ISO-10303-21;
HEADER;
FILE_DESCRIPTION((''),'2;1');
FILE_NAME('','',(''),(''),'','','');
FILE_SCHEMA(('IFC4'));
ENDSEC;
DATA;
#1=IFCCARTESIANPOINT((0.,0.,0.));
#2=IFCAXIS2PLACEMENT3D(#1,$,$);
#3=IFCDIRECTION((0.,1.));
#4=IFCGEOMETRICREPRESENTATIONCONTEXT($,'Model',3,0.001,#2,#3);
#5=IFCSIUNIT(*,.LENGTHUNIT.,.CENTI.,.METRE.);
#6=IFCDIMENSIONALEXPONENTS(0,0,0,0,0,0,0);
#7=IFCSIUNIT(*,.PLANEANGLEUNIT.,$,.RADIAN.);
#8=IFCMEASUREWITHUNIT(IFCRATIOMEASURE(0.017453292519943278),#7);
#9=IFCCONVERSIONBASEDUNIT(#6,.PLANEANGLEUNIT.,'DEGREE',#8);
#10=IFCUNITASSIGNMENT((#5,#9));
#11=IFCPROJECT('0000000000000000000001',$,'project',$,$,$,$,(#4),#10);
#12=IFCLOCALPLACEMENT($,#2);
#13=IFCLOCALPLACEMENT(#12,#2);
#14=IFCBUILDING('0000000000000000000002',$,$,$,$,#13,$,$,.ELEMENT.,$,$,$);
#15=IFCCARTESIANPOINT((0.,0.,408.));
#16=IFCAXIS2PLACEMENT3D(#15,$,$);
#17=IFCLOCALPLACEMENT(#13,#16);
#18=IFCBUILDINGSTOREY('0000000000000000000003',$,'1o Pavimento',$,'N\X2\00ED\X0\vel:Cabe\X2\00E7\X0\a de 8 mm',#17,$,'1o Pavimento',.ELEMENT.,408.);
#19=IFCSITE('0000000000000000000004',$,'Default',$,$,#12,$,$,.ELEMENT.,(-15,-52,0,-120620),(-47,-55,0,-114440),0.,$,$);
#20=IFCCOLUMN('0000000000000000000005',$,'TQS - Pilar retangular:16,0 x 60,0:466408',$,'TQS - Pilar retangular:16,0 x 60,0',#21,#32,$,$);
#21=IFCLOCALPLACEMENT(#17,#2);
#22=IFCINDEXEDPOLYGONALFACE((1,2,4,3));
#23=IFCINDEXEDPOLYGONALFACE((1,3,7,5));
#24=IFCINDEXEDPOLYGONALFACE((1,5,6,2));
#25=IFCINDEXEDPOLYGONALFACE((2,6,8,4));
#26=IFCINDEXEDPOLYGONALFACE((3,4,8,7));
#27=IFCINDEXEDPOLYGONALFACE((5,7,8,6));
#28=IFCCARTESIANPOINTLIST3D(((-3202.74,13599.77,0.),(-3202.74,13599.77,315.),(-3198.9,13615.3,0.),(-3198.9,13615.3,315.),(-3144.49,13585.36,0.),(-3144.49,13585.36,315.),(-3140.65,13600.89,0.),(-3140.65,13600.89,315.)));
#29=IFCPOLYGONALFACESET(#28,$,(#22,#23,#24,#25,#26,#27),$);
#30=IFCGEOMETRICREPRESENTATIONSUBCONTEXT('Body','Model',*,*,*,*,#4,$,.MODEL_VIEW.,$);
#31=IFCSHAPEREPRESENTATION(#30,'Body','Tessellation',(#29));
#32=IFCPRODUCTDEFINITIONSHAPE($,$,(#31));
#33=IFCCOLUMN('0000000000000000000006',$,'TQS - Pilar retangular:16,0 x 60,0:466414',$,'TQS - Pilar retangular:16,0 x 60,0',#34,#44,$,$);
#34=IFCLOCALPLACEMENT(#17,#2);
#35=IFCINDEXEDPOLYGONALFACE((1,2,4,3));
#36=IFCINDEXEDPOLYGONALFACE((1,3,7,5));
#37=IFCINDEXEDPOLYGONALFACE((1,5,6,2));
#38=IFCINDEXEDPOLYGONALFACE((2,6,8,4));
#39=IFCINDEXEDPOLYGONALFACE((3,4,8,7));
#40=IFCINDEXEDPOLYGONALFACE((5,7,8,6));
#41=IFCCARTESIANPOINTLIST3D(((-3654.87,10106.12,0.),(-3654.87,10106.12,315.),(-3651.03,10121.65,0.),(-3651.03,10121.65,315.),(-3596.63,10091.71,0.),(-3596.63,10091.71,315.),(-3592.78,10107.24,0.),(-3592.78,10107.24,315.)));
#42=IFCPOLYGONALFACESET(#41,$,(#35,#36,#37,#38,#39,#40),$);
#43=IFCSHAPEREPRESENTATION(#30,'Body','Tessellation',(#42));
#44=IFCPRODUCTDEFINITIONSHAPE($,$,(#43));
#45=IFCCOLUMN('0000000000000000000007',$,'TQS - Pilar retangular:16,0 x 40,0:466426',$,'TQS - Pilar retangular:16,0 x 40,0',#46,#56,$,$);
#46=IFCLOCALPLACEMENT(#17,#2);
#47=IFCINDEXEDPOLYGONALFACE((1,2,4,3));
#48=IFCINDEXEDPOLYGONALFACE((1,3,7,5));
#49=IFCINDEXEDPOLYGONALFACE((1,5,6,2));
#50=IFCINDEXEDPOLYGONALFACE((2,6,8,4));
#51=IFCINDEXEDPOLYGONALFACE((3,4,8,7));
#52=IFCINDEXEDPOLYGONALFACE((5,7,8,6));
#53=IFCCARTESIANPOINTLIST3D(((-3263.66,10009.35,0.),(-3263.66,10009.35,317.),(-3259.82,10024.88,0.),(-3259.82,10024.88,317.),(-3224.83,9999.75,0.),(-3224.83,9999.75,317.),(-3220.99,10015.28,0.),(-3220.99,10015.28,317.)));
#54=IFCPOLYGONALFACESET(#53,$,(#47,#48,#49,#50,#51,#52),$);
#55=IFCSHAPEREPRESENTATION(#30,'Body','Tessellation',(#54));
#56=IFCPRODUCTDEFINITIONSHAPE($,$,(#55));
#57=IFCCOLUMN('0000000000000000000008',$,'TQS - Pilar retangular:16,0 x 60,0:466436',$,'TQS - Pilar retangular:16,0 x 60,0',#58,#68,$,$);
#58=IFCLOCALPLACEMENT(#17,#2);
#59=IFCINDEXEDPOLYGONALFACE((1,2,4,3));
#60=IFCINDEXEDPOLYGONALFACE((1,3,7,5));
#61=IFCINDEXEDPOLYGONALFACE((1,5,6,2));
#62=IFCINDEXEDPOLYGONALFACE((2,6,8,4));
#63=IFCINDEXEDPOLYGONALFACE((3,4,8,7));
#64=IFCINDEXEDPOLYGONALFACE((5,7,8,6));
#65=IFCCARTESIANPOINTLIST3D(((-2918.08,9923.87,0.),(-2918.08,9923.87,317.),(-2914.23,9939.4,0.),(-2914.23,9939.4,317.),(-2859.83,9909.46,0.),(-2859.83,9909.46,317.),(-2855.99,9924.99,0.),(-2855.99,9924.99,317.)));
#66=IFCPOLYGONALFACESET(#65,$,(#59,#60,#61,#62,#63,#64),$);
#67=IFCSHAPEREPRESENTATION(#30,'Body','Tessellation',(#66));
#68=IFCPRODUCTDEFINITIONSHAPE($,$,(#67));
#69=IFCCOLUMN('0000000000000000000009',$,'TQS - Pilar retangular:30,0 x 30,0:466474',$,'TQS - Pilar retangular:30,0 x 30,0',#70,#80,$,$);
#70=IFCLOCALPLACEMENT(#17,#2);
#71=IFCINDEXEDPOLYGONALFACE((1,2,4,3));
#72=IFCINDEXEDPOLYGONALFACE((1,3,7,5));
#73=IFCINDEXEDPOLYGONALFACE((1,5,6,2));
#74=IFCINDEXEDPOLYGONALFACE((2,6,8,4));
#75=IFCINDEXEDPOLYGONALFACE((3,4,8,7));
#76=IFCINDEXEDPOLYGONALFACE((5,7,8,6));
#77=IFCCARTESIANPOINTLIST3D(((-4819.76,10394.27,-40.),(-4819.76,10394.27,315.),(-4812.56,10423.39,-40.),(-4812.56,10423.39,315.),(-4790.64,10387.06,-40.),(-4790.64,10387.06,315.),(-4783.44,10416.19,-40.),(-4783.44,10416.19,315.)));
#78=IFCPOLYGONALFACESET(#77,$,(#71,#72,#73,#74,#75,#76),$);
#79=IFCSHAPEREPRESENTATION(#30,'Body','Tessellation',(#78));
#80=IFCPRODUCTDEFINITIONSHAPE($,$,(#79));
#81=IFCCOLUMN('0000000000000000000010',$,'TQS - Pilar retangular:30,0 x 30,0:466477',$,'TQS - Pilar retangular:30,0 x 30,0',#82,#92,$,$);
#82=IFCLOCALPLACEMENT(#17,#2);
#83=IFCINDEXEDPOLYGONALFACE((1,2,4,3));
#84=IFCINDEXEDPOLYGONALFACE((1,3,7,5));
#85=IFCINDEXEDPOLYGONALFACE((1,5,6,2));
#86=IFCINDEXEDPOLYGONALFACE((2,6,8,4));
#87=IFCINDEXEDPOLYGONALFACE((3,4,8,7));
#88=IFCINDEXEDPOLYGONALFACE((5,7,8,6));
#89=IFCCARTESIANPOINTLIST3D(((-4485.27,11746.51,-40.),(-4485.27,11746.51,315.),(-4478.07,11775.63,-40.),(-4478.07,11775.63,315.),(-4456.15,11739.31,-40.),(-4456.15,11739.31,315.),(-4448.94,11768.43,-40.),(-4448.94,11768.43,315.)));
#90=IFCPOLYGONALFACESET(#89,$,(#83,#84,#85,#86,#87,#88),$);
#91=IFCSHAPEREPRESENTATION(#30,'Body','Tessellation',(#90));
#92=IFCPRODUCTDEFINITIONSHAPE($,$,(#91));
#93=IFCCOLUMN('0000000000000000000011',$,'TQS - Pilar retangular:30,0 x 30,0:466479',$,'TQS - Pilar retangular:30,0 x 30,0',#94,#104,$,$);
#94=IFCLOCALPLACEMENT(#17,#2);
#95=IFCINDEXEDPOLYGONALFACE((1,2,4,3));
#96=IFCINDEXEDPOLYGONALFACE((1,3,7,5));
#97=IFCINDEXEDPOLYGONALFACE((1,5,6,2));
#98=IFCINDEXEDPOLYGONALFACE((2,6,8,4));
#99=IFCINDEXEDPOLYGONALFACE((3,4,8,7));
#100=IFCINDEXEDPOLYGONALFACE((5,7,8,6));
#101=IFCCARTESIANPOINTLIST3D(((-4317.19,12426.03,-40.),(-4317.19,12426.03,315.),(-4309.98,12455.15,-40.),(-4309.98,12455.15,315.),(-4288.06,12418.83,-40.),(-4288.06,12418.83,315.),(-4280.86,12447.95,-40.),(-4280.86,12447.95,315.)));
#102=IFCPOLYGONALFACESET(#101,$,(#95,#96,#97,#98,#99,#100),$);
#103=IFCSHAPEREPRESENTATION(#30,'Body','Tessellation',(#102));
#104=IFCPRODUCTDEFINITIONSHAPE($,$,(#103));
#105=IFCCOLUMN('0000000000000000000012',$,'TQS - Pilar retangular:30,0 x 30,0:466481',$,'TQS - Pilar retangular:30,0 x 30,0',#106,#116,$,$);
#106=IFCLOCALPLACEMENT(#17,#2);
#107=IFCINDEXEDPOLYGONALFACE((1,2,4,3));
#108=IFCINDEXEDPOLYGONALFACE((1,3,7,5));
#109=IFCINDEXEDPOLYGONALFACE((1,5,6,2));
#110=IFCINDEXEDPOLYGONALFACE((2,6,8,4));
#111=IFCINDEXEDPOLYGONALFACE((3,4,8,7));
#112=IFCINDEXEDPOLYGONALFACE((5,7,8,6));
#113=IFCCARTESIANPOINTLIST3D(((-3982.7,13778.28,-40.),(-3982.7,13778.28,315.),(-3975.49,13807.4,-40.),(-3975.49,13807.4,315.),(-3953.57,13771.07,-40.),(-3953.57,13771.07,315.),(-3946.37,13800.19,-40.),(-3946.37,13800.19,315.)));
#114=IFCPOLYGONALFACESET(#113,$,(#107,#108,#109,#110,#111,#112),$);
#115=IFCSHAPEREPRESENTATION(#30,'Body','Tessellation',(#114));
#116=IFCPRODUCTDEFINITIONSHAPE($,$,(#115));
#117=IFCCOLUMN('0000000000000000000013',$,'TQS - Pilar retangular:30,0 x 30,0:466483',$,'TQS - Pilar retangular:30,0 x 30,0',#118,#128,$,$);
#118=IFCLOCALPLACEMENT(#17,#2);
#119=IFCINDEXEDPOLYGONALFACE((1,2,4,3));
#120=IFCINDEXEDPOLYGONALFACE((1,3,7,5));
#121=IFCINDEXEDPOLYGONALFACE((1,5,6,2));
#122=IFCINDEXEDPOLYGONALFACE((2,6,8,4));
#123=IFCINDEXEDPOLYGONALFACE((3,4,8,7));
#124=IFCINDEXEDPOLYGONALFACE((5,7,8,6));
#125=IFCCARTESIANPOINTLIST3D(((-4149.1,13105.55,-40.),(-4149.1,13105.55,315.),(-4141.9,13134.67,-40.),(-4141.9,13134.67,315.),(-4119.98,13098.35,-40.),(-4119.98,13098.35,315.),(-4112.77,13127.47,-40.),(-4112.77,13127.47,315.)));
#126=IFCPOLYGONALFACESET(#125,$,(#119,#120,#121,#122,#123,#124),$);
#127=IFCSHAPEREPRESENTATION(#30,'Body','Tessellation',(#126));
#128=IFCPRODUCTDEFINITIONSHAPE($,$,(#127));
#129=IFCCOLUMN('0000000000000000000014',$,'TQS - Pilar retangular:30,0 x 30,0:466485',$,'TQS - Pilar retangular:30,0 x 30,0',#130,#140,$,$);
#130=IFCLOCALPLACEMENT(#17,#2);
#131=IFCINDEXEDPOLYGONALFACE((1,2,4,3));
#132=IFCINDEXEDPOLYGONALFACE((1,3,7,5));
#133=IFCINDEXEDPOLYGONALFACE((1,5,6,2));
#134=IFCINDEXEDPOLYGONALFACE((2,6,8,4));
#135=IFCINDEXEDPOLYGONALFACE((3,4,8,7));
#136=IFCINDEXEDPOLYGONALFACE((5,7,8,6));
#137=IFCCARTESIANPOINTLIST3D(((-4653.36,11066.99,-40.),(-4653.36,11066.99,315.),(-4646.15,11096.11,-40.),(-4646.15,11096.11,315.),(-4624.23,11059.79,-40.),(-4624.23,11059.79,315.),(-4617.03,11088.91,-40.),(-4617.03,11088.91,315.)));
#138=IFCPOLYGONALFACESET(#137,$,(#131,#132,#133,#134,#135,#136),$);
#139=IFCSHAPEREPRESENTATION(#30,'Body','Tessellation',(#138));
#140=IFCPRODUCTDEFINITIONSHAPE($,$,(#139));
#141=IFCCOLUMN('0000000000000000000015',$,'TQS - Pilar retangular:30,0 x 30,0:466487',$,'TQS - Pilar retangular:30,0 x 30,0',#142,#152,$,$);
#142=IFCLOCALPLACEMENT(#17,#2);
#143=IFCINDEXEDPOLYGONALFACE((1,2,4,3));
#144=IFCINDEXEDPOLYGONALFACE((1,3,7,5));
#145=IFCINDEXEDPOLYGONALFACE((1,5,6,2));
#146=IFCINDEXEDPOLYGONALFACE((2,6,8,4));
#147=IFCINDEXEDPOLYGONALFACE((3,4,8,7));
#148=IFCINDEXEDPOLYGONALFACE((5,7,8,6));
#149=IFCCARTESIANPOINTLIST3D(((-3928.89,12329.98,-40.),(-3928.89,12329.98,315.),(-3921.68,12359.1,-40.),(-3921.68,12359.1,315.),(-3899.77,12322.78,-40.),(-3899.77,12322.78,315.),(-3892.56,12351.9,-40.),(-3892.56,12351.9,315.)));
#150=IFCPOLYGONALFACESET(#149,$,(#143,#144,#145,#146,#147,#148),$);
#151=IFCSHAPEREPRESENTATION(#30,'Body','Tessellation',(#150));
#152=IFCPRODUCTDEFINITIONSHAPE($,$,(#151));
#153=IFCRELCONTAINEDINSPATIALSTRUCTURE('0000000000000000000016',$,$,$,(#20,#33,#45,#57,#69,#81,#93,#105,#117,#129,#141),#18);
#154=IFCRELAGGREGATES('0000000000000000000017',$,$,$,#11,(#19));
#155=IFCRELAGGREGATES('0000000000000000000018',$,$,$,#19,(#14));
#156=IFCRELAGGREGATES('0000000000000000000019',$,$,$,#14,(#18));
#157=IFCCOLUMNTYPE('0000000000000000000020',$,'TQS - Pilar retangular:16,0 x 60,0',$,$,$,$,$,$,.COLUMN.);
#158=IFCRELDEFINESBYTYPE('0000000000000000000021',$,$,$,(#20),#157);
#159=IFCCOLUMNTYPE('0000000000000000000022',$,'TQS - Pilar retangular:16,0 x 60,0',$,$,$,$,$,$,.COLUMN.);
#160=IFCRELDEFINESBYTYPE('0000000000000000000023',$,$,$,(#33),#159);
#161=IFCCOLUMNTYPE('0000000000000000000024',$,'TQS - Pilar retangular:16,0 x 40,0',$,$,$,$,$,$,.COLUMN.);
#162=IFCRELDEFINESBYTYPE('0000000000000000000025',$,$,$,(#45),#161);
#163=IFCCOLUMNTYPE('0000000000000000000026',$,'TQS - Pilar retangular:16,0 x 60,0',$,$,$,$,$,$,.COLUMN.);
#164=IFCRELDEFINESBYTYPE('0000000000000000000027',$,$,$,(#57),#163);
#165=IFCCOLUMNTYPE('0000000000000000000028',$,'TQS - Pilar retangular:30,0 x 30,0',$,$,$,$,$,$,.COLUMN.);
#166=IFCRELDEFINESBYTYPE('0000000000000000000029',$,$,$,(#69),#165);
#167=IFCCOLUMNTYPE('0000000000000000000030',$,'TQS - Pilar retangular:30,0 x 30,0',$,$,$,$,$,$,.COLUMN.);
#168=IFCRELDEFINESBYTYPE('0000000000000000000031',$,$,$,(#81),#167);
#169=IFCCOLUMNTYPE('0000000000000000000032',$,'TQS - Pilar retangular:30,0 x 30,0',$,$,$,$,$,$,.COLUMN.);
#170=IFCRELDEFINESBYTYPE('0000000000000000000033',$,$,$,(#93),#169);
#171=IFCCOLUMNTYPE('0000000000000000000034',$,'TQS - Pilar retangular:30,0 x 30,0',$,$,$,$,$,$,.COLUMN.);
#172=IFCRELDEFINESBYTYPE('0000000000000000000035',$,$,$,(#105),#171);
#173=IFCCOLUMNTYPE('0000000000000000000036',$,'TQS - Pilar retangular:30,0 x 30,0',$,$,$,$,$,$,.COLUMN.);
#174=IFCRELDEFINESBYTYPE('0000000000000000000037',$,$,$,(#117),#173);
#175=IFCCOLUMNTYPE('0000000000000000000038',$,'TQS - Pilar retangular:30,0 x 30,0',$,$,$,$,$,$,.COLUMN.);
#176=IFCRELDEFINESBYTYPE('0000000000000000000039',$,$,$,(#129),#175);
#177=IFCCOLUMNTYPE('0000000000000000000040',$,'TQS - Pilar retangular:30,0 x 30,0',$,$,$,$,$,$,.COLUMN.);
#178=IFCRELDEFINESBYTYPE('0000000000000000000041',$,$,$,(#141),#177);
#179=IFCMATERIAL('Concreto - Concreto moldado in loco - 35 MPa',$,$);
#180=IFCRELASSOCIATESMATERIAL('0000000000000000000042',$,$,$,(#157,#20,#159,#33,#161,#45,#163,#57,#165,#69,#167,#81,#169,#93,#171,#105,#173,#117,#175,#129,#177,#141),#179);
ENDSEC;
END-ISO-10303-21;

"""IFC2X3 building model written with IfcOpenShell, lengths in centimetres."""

from ifc_helpers import new_model, entity, si_unit, converted_unit, direction, frame, origin, origin_2d_with_axis, place, context, subcontext, project, spatial, rectangle, extrude, source, transform, mapped, material, type_object, type_shapes, element, save


model = new_model("IFC2X3")

# Units and contexts
model_context = context("Model", 3, precision=0.001, world=origin(), true_north=direction((0.0, 1.0)))
body_context = subcontext(model_context, "Body", "Model", "MODEL_VIEW")
ifc_project = project(units=[si_unit("LENGTHUNIT", "METRE", prefix="CENTI"), converted_unit("PLANEANGLEUNIT", "DEGREE", entity("IfcRatioMeasure", 0.017453292519943278), si_unit("PLANEANGLEUNIT", "RADIAN"), dimensions=[0, 0, 0, 0, 0, 0, 0])], contexts=[model_context])

# Site, building, storey
site_placement = place(None, origin())
site = spatial("IfcSite", under=ifc_project, at=site_placement, Name="Default", CompositionType="ELEMENT", RefLatitude=(-15, -52, 0, -120620), RefLongitude=(-47, -55, 0, -114440), RefElevation=0.0)
building_placement = place(site_placement, origin())
building = spatial("IfcBuilding", under=site, at=building_placement, CompositionType="ELEMENT")
storey_placement = place(building_placement, frame((0.0, 0.0, 408.0)))
storey = spatial("IfcBuildingStorey", under=building, at=storey_placement, Name="1o Pavimento", ObjectType="Nível:Cabeça de 8 mm", LongName="1o Pavimento", CompositionType="ELEMENT", Elevation=408.0)

# Columns
ifc_material = material(Name="Concreto - Concreto moldado in loco - 35 MPa")
column_type_1 = type_object("IfcColumnType", Name="TQS - Pilar retangular:16,0 x 60,0", PredefinedType="COLUMN", material=ifc_material)
shared_shape_1 = source(origin(), body_context, "Body", "SweptSolid", [
    extrude(rectangle(XDim=60.0, YDim=16.0, at=origin_2d_with_axis()), frame((-3171.7, 13600.33, 408.0), z_axis=(0.0, 0.0, 1.0), x_axis=(-0.970743, 0.240122, 0.0)), (0.0, 0.0, 1.0), 315.0),
])
type_shapes(column_type_1, [shared_shape_1])
column_1_placement = place(storey_placement, frame((0.0, 0.0, -408.0)))
element("IfcColumn", 1, at=column_1_placement, inside=storey, type_object=column_type_1, material=ifc_material, Name="TQS - Pilar retangular:16,0 x 60,0:466408", ObjectType="TQS - Pilar retangular:16,0 x 60,0", context=body_context, shape_type="MappedRepresentation", body=[
    mapped(shared_shape_1, transform((0.0, 0.0, 0.0), scale=1.0)),
])
column_type_2 = type_object("IfcColumnType", Name="TQS - Pilar retangular:16,0 x 60,0", PredefinedType="COLUMN", material=ifc_material)
shared_shape_2 = source(origin(), body_context, "Body", "SweptSolid", [
    extrude(rectangle(XDim=60.0, YDim=16.0, at=origin_2d_with_axis()), frame((-3623.83, 10106.68, 408.0), z_axis=(0.0, 0.0, 1.0), x_axis=(-0.970743, 0.240122, 0.0)), (0.0, 0.0, 1.0), 315.0),
])
type_shapes(column_type_2, [shared_shape_2])
column_2_placement = place(storey_placement, frame((0.0, 0.0, -408.0)))
element("IfcColumn", 2, at=column_2_placement, inside=storey, type_object=column_type_2, material=ifc_material, Name="TQS - Pilar retangular:16,0 x 60,0:466414", ObjectType="TQS - Pilar retangular:16,0 x 60,0", context=body_context, shape_type="MappedRepresentation", body=[
    mapped(shared_shape_2, transform((0.0, 0.0, 0.0), scale=1.0)),
])
column_type_3 = type_object("IfcColumnType", Name="TQS - Pilar retangular:16,0 x 40,0", PredefinedType="COLUMN", material=ifc_material)
shared_shape_3 = source(origin(), body_context, "Body", "SweptSolid", [
    extrude(rectangle(XDim=40.0, YDim=16.0, at=origin_2d_with_axis()), frame((-3242.33, 10012.31, 408.0), z_axis=(0.0, 0.0, 1.0), x_axis=(-0.970743, 0.240122, 0.0)), (0.0, 0.0, 1.0), 317.0),
])
type_shapes(column_type_3, [shared_shape_3])
column_3_placement = place(storey_placement, frame((0.0, 0.0, -408.0)))
element("IfcColumn", 3, at=column_3_placement, inside=storey, type_object=column_type_3, material=ifc_material, Name="TQS - Pilar retangular:16,0 x 40,0:466426", ObjectType="TQS - Pilar retangular:16,0 x 40,0", context=body_context, shape_type="MappedRepresentation", body=[
    mapped(shared_shape_3, transform((0.0, 0.0, 0.0), scale=1.0)),
])
column_type_4 = type_object("IfcColumnType", Name="TQS - Pilar retangular:16,0 x 60,0", PredefinedType="COLUMN", material=ifc_material)
shared_shape_4 = source(origin(), body_context, "Body", "SweptSolid", [
    extrude(rectangle(XDim=60.0, YDim=16.0, at=origin_2d_with_axis()), frame((-2887.03, 9924.43, 408.0), z_axis=(0.0, 0.0, 1.0), x_axis=(-0.970743, 0.240122, 0.0)), (0.0, 0.0, 1.0), 317.0),
])
type_shapes(column_type_4, [shared_shape_4])
column_4_placement = place(storey_placement, frame((0.0, 0.0, -408.0)))
element("IfcColumn", 4, at=column_4_placement, inside=storey, type_object=column_type_4, material=ifc_material, Name="TQS - Pilar retangular:16,0 x 60,0:466436", ObjectType="TQS - Pilar retangular:16,0 x 60,0", context=body_context, shape_type="MappedRepresentation", body=[
    mapped(shared_shape_4, transform((0.0, 0.0, 0.0), scale=1.0)),
])
column_type_5 = type_object("IfcColumnType", Name="TQS - Pilar retangular:30,0 x 30,0", PredefinedType="COLUMN", material=ifc_material)
shared_shape_5 = source(origin(), body_context, "Body", "SweptSolid", [
    extrude(rectangle(XDim=30.0, YDim=30.0, at=origin_2d_with_axis()), frame((-4801.6, 10405.23, 368.0), z_axis=(0.0, 0.0, 1.0), x_axis=(-0.970743, 0.240122, 0.0)), (0.0, 0.0, 1.0), 355.0),
])
type_shapes(column_type_5, [shared_shape_5])
column_5_placement = place(storey_placement, frame((0.0, 0.0, -408.0)))
element("IfcColumn", 5, at=column_5_placement, inside=storey, type_object=column_type_5, material=ifc_material, Name="TQS - Pilar retangular:30,0 x 30,0:466474", ObjectType="TQS - Pilar retangular:30,0 x 30,0", context=body_context, shape_type="MappedRepresentation", body=[
    mapped(shared_shape_5, transform((0.0, 0.0, 0.0), scale=1.0)),
])
column_type_6 = type_object("IfcColumnType", Name="TQS - Pilar retangular:30,0 x 30,0", PredefinedType="COLUMN", material=ifc_material)
shared_shape_6 = source(origin(), body_context, "Body", "SweptSolid", [
    extrude(rectangle(XDim=30.0, YDim=30.0, at=origin_2d_with_axis()), frame((-4467.11, 11757.47, 368.0), z_axis=(0.0, 0.0, 1.0), x_axis=(-0.970743, 0.240122, 0.0)), (0.0, 0.0, 1.0), 355.0),
])
type_shapes(column_type_6, [shared_shape_6])
column_6_placement = place(storey_placement, frame((0.0, 0.0, -408.0)))
element("IfcColumn", 6, at=column_6_placement, inside=storey, type_object=column_type_6, material=ifc_material, Name="TQS - Pilar retangular:30,0 x 30,0:466477", ObjectType="TQS - Pilar retangular:30,0 x 30,0", context=body_context, shape_type="MappedRepresentation", body=[
    mapped(shared_shape_6, transform((0.0, 0.0, 0.0), scale=1.0)),
])
column_type_7 = type_object("IfcColumnType", Name="TQS - Pilar retangular:30,0 x 30,0", PredefinedType="COLUMN", material=ifc_material)
shared_shape_7 = source(origin(), body_context, "Body", "SweptSolid", [
    extrude(rectangle(XDim=30.0, YDim=30.0, at=origin_2d_with_axis()), frame((-4299.02, 12436.99, 368.0), z_axis=(0.0, 0.0, 1.0), x_axis=(-0.970743, 0.240122, 0.0)), (0.0, 0.0, 1.0), 355.0),
])
type_shapes(column_type_7, [shared_shape_7])
column_7_placement = place(storey_placement, frame((0.0, 0.0, -408.0)))
element("IfcColumn", 7, at=column_7_placement, inside=storey, type_object=column_type_7, material=ifc_material, Name="TQS - Pilar retangular:30,0 x 30,0:466479", ObjectType="TQS - Pilar retangular:30,0 x 30,0", context=body_context, shape_type="MappedRepresentation", body=[
    mapped(shared_shape_7, transform((0.0, 0.0, 0.0), scale=1.0)),
])
column_type_8 = type_object("IfcColumnType", Name="TQS - Pilar retangular:30,0 x 30,0", PredefinedType="COLUMN", material=ifc_material)
shared_shape_8 = source(origin(), body_context, "Body", "SweptSolid", [
    extrude(rectangle(XDim=30.0, YDim=30.0, at=origin_2d_with_axis()), frame((-3964.53, 13789.23, 368.0), z_axis=(0.0, 0.0, 1.0), x_axis=(-0.970743, 0.240122, 0.0)), (0.0, 0.0, 1.0), 355.0),
])
type_shapes(column_type_8, [shared_shape_8])
column_8_placement = place(storey_placement, frame((0.0, 0.0, -408.0)))
element("IfcColumn", 8, at=column_8_placement, inside=storey, type_object=column_type_8, material=ifc_material, Name="TQS - Pilar retangular:30,0 x 30,0:466481", ObjectType="TQS - Pilar retangular:30,0 x 30,0", context=body_context, shape_type="MappedRepresentation", body=[
    mapped(shared_shape_8, transform((0.0, 0.0, 0.0), scale=1.0)),
])
column_type_9 = type_object("IfcColumnType", Name="TQS - Pilar retangular:30,0 x 30,0", PredefinedType="COLUMN", material=ifc_material)
shared_shape_9 = source(origin(), body_context, "Body", "SweptSolid", [
    extrude(rectangle(XDim=30.0, YDim=30.0, at=origin_2d_with_axis()), frame((-4130.94, 13116.51, 368.0), z_axis=(0.0, 0.0, 1.0), x_axis=(-0.970743, 0.240122, 0.0)), (0.0, 0.0, 1.0), 355.0),
])
type_shapes(column_type_9, [shared_shape_9])
column_9_placement = place(storey_placement, frame((0.0, 0.0, -408.0)))
element("IfcColumn", 9, at=column_9_placement, inside=storey, type_object=column_type_9, material=ifc_material, Name="TQS - Pilar retangular:30,0 x 30,0:466483", ObjectType="TQS - Pilar retangular:30,0 x 30,0", context=body_context, shape_type="MappedRepresentation", body=[
    mapped(shared_shape_9, transform((0.0, 0.0, 0.0), scale=1.0)),
])
column_type_10 = type_object("IfcColumnType", Name="TQS - Pilar retangular:30,0 x 30,0", PredefinedType="COLUMN", material=ifc_material)
shared_shape_10 = source(origin(), body_context, "Body", "SweptSolid", [
    extrude(rectangle(XDim=30.0, YDim=30.0, at=origin_2d_with_axis()), frame((-4635.19, 11077.95, 368.0), z_axis=(0.0, 0.0, 1.0), x_axis=(-0.970743, 0.240122, 0.0)), (0.0, 0.0, 1.0), 355.0),
])
type_shapes(column_type_10, [shared_shape_10])
column_10_placement = place(storey_placement, frame((0.0, 0.0, -408.0)))
element("IfcColumn", 10, at=column_10_placement, inside=storey, type_object=column_type_10, material=ifc_material, Name="TQS - Pilar retangular:30,0 x 30,0:466485", ObjectType="TQS - Pilar retangular:30,0 x 30,0", context=body_context, shape_type="MappedRepresentation", body=[
    mapped(shared_shape_10, transform((0.0, 0.0, 0.0), scale=1.0)),
])
column_type_11 = type_object("IfcColumnType", Name="TQS - Pilar retangular:30,0 x 30,0", PredefinedType="COLUMN", material=ifc_material)
shared_shape_11 = source(origin(), body_context, "Body", "SweptSolid", [
    extrude(rectangle(XDim=30.0, YDim=30.0, at=origin_2d_with_axis()), frame((-3910.73, 12340.94, 368.0), z_axis=(0.0, 0.0, 1.0), x_axis=(-0.970743, 0.240122, 0.0)), (0.0, 0.0, 1.0), 355.0),
])
type_shapes(column_type_11, [shared_shape_11])
column_11_placement = place(storey_placement, frame((0.0, 0.0, -408.0)))
element("IfcColumn", 11, at=column_11_placement, inside=storey, type_object=column_type_11, material=ifc_material, Name="TQS - Pilar retangular:30,0 x 30,0:466487", ObjectType="TQS - Pilar retangular:30,0 x 30,0", context=body_context, shape_type="MappedRepresentation", body=[
    mapped(shared_shape_11, transform((0.0, 0.0, 0.0), scale=1.0)),
])

save(model, "model.ifc")
